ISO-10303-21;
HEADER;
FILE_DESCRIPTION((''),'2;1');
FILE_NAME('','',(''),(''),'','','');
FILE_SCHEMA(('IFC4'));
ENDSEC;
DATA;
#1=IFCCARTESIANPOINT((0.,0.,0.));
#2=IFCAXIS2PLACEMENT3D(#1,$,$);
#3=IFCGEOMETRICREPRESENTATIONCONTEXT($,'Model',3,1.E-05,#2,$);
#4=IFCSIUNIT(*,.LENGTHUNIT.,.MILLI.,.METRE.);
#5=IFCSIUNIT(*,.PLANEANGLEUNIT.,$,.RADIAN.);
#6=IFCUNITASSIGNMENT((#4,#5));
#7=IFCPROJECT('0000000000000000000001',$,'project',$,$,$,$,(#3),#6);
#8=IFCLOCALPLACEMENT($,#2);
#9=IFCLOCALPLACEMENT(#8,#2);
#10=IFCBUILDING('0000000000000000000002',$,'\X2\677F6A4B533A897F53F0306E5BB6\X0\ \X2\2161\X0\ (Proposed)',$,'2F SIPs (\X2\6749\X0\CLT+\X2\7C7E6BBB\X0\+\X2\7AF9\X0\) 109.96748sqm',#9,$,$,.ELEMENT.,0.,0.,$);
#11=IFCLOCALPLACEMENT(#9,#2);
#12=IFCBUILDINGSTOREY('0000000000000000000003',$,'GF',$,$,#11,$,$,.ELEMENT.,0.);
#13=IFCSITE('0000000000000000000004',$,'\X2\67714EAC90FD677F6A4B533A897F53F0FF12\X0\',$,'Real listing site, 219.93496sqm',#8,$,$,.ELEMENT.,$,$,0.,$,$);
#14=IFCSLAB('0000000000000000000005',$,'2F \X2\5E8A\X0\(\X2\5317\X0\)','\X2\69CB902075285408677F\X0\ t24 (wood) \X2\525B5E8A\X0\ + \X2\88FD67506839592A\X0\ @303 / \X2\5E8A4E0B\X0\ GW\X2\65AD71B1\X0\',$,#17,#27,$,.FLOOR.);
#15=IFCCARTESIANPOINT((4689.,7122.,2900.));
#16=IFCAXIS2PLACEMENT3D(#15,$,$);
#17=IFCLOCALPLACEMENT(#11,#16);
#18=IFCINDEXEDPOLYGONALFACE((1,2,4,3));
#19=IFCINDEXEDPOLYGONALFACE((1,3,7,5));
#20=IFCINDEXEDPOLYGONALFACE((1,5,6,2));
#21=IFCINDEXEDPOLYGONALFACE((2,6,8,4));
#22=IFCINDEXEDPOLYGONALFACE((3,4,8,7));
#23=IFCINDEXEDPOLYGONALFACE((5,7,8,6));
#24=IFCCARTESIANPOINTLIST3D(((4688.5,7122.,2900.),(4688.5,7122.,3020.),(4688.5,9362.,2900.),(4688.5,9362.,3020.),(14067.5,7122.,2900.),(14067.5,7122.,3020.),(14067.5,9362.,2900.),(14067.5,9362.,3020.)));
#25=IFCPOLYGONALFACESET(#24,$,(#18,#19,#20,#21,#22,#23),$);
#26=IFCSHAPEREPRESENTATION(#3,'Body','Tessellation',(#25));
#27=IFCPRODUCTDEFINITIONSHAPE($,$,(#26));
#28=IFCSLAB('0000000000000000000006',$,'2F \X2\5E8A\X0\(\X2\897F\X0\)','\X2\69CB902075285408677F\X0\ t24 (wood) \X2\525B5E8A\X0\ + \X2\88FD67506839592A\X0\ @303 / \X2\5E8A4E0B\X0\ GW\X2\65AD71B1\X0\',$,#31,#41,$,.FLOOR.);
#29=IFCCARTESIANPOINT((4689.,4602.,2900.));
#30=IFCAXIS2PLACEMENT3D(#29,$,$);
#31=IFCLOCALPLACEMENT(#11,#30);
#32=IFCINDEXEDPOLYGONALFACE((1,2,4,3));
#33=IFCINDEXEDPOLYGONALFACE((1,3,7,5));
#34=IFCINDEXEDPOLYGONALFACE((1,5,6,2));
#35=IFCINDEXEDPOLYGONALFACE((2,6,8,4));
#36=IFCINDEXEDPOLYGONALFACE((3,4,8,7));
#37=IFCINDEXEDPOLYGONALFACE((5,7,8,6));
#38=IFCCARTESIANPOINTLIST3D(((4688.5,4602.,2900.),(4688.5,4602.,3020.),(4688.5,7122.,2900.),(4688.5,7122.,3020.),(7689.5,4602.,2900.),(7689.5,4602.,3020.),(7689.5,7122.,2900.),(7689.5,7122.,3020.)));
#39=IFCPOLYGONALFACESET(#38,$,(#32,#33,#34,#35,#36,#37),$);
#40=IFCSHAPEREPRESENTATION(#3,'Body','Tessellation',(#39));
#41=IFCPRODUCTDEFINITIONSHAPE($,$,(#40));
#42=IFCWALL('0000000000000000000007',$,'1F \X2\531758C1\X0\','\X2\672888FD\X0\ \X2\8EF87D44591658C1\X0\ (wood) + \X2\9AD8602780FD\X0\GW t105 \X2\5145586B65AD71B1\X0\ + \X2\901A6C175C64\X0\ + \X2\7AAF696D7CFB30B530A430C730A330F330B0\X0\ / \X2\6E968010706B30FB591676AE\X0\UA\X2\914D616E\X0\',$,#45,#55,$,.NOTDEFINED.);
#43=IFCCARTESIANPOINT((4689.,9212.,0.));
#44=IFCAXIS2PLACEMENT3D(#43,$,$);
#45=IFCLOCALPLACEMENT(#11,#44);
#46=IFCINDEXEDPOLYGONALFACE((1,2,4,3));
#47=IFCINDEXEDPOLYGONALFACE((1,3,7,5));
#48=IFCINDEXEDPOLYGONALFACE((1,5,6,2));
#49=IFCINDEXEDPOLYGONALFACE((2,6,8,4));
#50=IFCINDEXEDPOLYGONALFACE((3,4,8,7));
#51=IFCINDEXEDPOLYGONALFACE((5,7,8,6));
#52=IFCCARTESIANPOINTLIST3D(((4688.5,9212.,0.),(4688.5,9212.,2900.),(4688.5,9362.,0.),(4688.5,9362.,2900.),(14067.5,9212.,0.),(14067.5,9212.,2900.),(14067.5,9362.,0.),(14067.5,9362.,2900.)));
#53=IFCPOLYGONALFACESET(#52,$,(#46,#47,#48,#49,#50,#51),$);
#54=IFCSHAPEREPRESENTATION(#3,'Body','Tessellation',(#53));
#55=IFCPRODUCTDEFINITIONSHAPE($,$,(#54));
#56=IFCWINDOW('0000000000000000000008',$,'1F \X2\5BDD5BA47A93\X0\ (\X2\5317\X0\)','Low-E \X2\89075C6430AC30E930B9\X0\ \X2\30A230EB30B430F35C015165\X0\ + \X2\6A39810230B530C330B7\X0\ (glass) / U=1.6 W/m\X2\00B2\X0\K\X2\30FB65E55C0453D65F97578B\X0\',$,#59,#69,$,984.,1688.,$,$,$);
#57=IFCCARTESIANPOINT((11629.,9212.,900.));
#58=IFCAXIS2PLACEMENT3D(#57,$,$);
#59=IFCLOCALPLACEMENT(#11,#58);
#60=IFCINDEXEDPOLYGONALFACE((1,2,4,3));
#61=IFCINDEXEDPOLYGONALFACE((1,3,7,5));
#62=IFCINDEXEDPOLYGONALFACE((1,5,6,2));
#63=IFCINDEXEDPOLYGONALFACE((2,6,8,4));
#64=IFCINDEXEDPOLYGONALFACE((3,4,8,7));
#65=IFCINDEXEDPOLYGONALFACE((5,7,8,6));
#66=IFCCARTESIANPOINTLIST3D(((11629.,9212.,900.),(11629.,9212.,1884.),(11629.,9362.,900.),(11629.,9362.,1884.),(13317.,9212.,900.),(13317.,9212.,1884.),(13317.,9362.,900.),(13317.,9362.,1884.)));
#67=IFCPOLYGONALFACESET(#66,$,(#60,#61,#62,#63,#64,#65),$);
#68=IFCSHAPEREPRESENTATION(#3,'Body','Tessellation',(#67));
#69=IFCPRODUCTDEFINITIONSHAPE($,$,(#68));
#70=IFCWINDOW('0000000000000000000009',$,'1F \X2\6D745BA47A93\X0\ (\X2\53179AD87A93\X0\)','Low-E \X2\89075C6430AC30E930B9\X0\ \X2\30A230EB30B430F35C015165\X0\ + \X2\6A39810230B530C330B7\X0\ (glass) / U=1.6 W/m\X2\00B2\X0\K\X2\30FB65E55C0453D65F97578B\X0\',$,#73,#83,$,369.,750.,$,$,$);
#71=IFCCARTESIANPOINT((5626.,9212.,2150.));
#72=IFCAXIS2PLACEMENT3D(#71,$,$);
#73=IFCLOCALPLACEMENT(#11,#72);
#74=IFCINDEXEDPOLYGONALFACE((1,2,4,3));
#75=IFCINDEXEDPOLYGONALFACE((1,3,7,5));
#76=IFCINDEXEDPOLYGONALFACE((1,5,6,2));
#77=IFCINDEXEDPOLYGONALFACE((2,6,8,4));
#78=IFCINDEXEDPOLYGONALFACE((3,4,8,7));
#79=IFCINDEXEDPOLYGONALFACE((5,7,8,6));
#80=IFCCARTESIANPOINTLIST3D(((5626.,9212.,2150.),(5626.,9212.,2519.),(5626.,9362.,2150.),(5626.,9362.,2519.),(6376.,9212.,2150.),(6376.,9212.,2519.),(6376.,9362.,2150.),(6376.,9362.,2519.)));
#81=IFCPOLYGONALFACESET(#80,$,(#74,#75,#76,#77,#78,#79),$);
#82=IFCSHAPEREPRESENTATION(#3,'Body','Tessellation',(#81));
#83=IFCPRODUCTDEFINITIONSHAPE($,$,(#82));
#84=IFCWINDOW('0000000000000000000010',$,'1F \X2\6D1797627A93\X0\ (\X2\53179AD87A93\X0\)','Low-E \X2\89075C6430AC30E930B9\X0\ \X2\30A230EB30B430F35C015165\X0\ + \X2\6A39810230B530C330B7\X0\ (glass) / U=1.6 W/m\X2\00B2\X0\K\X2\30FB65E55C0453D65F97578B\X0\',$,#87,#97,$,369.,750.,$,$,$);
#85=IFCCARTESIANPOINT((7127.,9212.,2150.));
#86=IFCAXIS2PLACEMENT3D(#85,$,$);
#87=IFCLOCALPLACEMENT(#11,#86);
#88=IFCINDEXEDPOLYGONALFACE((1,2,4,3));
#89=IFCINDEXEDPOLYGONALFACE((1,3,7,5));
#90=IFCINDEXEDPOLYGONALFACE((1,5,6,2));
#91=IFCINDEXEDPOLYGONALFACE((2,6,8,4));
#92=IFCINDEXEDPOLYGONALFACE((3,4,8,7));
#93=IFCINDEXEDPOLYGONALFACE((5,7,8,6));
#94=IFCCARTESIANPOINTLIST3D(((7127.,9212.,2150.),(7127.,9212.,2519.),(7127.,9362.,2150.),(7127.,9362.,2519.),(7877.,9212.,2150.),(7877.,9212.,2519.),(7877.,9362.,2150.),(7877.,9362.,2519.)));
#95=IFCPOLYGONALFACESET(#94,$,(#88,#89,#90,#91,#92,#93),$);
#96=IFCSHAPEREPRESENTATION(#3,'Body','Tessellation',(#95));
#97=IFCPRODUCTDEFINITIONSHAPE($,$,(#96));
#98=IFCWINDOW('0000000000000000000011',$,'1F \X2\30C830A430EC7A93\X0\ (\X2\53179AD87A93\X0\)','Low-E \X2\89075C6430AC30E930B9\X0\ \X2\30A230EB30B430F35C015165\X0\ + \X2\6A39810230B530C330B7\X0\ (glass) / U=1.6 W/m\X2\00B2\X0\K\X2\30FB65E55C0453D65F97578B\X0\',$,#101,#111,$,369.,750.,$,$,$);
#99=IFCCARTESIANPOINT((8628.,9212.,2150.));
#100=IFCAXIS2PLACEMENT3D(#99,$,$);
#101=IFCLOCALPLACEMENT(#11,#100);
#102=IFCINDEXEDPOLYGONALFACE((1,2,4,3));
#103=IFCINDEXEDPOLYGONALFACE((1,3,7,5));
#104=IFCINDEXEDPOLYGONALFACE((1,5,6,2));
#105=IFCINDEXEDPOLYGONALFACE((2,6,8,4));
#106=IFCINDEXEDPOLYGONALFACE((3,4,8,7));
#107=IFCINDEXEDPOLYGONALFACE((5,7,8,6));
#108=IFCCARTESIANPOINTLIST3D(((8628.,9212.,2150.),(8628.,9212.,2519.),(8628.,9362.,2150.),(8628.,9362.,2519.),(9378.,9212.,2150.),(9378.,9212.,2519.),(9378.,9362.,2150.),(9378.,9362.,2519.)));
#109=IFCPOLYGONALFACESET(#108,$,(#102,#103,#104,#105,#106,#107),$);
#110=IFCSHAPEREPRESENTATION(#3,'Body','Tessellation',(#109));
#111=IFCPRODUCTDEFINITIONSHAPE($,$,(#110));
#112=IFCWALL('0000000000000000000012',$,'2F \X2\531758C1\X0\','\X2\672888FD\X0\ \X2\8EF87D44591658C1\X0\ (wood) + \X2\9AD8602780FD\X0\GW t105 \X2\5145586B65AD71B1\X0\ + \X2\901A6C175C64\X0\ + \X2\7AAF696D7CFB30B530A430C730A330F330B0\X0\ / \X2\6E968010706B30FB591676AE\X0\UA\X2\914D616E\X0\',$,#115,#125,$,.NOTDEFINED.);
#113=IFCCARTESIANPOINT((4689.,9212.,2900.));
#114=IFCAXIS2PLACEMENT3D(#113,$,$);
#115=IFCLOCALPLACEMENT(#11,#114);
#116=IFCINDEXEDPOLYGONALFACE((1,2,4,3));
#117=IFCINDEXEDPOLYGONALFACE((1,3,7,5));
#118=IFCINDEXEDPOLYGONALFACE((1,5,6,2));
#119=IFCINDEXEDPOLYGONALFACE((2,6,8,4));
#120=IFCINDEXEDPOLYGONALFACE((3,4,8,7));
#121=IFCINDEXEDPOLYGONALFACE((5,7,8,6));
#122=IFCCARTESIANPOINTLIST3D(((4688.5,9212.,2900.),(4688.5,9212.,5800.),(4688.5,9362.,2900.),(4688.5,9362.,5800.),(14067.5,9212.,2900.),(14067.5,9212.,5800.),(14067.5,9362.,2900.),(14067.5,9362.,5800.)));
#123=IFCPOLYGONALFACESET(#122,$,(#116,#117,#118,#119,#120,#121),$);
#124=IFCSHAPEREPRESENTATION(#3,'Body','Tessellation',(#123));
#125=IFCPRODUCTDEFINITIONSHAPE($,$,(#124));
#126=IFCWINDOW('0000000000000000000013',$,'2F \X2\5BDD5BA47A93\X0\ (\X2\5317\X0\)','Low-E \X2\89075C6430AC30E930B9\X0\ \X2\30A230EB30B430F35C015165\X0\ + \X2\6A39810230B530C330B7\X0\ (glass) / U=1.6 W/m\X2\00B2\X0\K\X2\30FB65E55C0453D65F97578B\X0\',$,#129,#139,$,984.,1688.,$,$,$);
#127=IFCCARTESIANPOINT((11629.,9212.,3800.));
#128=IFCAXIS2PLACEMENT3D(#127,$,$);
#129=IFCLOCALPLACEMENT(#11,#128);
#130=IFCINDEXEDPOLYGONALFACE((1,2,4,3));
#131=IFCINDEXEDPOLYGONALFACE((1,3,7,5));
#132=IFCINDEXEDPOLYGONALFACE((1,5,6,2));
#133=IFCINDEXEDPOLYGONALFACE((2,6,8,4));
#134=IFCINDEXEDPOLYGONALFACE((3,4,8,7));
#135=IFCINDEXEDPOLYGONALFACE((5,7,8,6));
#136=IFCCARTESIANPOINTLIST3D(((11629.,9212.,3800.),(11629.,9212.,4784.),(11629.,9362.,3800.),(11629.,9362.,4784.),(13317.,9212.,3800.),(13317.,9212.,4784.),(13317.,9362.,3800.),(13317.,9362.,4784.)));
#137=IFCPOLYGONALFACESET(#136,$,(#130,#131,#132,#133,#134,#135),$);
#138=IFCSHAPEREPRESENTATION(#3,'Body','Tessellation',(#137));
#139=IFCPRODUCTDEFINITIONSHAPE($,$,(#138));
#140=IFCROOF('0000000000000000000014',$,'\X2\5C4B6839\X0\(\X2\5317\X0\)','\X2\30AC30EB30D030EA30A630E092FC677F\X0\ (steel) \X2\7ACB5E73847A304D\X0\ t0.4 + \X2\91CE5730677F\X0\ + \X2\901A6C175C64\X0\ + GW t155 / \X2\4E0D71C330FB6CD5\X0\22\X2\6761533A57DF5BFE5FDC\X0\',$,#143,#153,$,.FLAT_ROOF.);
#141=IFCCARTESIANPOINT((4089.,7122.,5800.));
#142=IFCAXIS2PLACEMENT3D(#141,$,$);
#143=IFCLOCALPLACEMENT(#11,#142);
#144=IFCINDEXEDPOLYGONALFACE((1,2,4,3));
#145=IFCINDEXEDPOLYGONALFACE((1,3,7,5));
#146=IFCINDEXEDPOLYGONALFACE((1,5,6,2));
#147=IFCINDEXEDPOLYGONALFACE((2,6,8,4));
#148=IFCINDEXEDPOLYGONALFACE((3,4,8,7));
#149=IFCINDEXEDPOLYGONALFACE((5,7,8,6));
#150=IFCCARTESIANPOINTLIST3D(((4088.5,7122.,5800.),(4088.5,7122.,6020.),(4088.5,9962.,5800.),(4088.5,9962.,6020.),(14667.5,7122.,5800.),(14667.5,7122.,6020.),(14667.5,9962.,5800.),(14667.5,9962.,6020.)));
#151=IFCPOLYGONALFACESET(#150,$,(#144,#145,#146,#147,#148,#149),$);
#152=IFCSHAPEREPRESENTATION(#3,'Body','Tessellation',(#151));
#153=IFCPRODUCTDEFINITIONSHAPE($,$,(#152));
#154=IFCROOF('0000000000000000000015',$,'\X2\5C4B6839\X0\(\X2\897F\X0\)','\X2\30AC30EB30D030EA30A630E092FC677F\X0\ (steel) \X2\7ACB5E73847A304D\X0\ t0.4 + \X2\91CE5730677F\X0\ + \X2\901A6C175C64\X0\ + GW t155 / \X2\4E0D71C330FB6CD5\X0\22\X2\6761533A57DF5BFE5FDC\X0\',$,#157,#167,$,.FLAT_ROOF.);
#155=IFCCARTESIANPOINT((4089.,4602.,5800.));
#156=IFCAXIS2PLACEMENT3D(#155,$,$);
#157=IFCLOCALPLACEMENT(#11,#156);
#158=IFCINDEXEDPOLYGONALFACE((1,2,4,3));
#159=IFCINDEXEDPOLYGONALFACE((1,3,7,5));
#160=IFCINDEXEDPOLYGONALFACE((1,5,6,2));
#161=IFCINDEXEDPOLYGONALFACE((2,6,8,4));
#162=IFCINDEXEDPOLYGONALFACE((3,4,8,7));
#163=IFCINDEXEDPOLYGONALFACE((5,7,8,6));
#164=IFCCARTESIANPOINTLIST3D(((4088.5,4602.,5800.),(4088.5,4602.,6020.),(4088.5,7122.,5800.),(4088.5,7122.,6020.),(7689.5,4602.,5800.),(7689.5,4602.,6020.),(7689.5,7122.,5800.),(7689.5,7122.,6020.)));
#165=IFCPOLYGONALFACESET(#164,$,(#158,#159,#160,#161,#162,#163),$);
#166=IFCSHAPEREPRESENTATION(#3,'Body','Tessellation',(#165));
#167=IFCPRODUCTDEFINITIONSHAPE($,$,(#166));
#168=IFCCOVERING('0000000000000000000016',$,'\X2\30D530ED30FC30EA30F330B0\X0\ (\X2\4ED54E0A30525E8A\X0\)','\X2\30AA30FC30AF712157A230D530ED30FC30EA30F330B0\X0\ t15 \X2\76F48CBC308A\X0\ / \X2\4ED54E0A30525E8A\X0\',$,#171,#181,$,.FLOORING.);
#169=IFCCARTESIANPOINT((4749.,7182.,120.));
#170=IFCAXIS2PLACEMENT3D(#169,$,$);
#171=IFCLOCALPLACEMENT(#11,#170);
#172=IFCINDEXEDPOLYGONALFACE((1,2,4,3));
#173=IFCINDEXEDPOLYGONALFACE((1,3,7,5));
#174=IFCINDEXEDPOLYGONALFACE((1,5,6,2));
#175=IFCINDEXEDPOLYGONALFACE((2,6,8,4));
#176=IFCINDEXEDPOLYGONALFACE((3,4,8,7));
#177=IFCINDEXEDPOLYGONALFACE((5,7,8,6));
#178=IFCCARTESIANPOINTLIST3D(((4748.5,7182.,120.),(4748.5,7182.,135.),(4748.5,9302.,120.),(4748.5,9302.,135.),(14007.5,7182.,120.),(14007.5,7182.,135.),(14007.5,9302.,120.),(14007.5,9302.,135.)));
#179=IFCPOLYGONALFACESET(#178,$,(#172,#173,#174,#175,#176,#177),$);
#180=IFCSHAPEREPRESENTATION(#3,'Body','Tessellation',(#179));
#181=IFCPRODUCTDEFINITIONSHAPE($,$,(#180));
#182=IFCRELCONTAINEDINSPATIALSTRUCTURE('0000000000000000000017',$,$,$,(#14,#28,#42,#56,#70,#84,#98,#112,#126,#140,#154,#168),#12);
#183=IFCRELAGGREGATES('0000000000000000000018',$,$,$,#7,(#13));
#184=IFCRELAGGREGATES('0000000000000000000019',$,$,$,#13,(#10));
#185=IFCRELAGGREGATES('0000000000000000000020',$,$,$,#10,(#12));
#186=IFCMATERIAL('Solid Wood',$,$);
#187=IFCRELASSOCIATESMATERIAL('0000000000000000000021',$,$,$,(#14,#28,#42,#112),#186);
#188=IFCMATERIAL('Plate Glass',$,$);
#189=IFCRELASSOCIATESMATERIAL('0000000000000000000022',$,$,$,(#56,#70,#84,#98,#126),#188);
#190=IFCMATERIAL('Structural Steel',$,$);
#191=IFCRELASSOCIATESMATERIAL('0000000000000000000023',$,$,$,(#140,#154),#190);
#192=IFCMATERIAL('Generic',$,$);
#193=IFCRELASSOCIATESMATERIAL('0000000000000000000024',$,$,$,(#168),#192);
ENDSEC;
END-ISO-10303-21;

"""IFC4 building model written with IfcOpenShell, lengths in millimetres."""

from ifc_helpers import new_model, si_unit, frame, frame_2d, origin, place, context, project, spatial, rectangle, extrude, material, element, fill, save


model = new_model("IFC4")

# Units and contexts
model_context = context("Model", 3, precision=1e-05, world=origin())
ifc_project = project(units=[si_unit("LENGTHUNIT", "METRE", prefix="MILLI"), si_unit("PLANEANGLEUNIT", "RADIAN")], contexts=[model_context])

# Site, building, storey
site_placement = place(None, origin())
site = spatial("IfcSite", under=ifc_project, at=site_placement, Name="東京都板橋区西台２", ObjectType="Real listing site, 219.93496sqm", CompositionType="ELEMENT", RefElevation=0.0)
building_placement = place(site_placement, origin())
building = spatial("IfcBuilding", under=site, at=building_placement, Name="板橋区西台の家 Ⅱ (Proposed)", ObjectType="2F SIPs (杉CLT+籾殻+竹) 109.96748sqm", CompositionType="ELEMENT", ElevationOfRefHeight=0.0, ElevationOfTerrain=0.0)
storey_placement = place(building_placement, origin())
storey = spatial("IfcBuildingStorey", under=building, at=storey_placement, Name="GF", CompositionType="ELEMENT", Elevation=0.0)

# Slabs
ifc_material_1 = material(Name="Solid Wood")
slab_1_placement = place(storey_placement, frame((4689.0, 7122.0, 2900.0)))
element("IfcSlab", 1, at=slab_1_placement, inside=storey, material=ifc_material_1, Name="2F 床(北)", Description="構造用合板 t24 (wood) 剛床 + 製材根太 @303 / 床下 GW断熱", PredefinedType="FLOOR", context=model_context, shape_type="SweptSolid", body=[
    extrude(rectangle(XDim=9379.0, YDim=2240.0, at=frame_2d((4689.0, 1120.0))), frame((4689.0, 7122.0, 2900.0)), (0.0, 0.0, 1.0), 120.0),
])
slab_2_placement = place(storey_placement, frame((4689.0, 4602.0, 2900.0)))
element("IfcSlab", 2, at=slab_2_placement, inside=storey, material=ifc_material_1, Name="2F 床(西)", Description="構造用合板 t24 (wood) 剛床 + 製材根太 @303 / 床下 GW断熱", PredefinedType="FLOOR", context=model_context, shape_type="SweptSolid", body=[
    extrude(rectangle(XDim=3001.0, YDim=2520.0, at=frame_2d((1500.0, 1260.0))), frame((4689.0, 4602.0, 2900.0)), (0.0, 0.0, 1.0), 120.0),
])

# Wall, openings, windows
wall_1_placement = place(storey_placement, frame((4689.0, 9212.0, 0.0)))
wall_1 = element("IfcWall", 3, at=wall_1_placement, inside=storey, material=ifc_material_1, Name="1F 北壁", Description="木製 軸組外壁 (wood) + 高性能GW t105 充填断熱 + 通気層 + 窯業系サイディング / 準耐火・外皮UA配慮", PredefinedType="NOTDEFINED", context=model_context, shape_type="SweptSolid", body=[
    extrude(rectangle(XDim=9379.0, YDim=150.0, at=frame_2d((4689.0, 75.0))), frame((4689.0, 9212.0, 0.0)), (0.0, 0.0, 1.0), 2900.0),
])
opening_1_placement = place(storey_placement, frame((11629.0, 9212.0, 900.0)))
opening_1 = element("IfcOpeningElement", 4, at=opening_1_placement, cuts=wall_1, PredefinedType="NOTDEFINED", context=model_context, shape_type="SweptSolid", body=[
    extrude(rectangle(XDim=1688.0, YDim=150.0, at=frame_2d((844.0, 75.0))), frame((11629.0, 9212.0, 900.0)), (0.0, 0.0, 1.0), 984.0),
])
opening_2_placement = place(storey_placement, frame((5626.0, 9212.0, 2150.0)))
opening_2 = element("IfcOpeningElement", 5, at=opening_2_placement, cuts=wall_1, PredefinedType="NOTDEFINED", context=model_context, shape_type="SweptSolid", body=[
    extrude(rectangle(XDim=750.0, YDim=150.0, at=frame_2d((375.0, 75.0))), frame((5626.0, 9212.0, 2150.0)), (0.0, 0.0, 1.0), 369.0),
])
opening_3_placement = place(storey_placement, frame((7127.0, 9212.0, 2150.0)))
opening_3 = element("IfcOpeningElement", 6, at=opening_3_placement, cuts=wall_1, PredefinedType="NOTDEFINED", context=model_context, shape_type="SweptSolid", body=[
    extrude(rectangle(XDim=750.0, YDim=150.0, at=frame_2d((375.0, 75.0))), frame((7127.0, 9212.0, 2150.0)), (0.0, 0.0, 1.0), 369.0),
])
opening_4_placement = place(storey_placement, frame((8628.0, 9212.0, 2150.0)))
opening_4 = element("IfcOpeningElement", 7, at=opening_4_placement, cuts=wall_1, PredefinedType="NOTDEFINED", context=model_context, shape_type="SweptSolid", body=[
    extrude(rectangle(XDim=750.0, YDim=150.0, at=frame_2d((375.0, 75.0))), frame((8628.0, 9212.0, 2150.0)), (0.0, 0.0, 1.0), 369.0),
])
ifc_material_2 = material(Name="Plate Glass")
window_1_placement = place(storey_placement, frame((11629.0, 9212.0, 900.0)))
window_1 = element("IfcWindow", 8, at=window_1_placement, inside=storey, material=ifc_material_2, Name="1F 寝室窓 (北)", Description="Low-E 複層ガラス アルゴン封入 + 樹脂サッシ (glass) / U=1.6 W/m²K・日射取得型", OverallHeight=984.0, OverallWidth=1688.0, context=model_context, shape_type="SweptSolid", body=[
    extrude(rectangle(XDim=1688.0, YDim=150.0, at=frame_2d((844.0, 75.0))), frame((11629.0, 9212.0, 900.0)), (0.0, 0.0, 1.0), 984.0),
])
fill(opening_1, window_1)
window_2_placement = place(storey_placement, frame((5626.0, 9212.0, 2150.0)))
window_2 = element("IfcWindow", 9, at=window_2_placement, inside=storey, material=ifc_material_2, Name="1F 浴室窓 (北高窓)", Description="Low-E 複層ガラス アルゴン封入 + 樹脂サッシ (glass) / U=1.6 W/m²K・日射取得型", OverallHeight=369.0, OverallWidth=750.0, context=model_context, shape_type="SweptSolid", body=[
    extrude(rectangle(XDim=750.0, YDim=150.0, at=frame_2d((375.0, 75.0))), frame((5626.0, 9212.0, 2150.0)), (0.0, 0.0, 1.0), 369.0),
])
fill(opening_2, window_2)
window_3_placement = place(storey_placement, frame((7127.0, 9212.0, 2150.0)))
window_3 = element("IfcWindow", 10, at=window_3_placement, inside=storey, material=ifc_material_2, Name="1F 洗面窓 (北高窓)", Description="Low-E 複層ガラス アルゴン封入 + 樹脂サッシ (glass) / U=1.6 W/m²K・日射取得型", OverallHeight=369.0, OverallWidth=750.0, context=model_context, shape_type="SweptSolid", body=[
    extrude(rectangle(XDim=750.0, YDim=150.0, at=frame_2d((375.0, 75.0))), frame((7127.0, 9212.0, 2150.0)), (0.0, 0.0, 1.0), 369.0),
])
fill(opening_3, window_3)
window_4_placement = place(storey_placement, frame((8628.0, 9212.0, 2150.0)))
window_4 = element("IfcWindow", 11, at=window_4_placement, inside=storey, material=ifc_material_2, Name="1F トイレ窓 (北高窓)", Description="Low-E 複層ガラス アルゴン封入 + 樹脂サッシ (glass) / U=1.6 W/m²K・日射取得型", OverallHeight=369.0, OverallWidth=750.0, context=model_context, shape_type="SweptSolid", body=[
    extrude(rectangle(XDim=750.0, YDim=150.0, at=frame_2d((375.0, 75.0))), frame((8628.0, 9212.0, 2150.0)), (0.0, 0.0, 1.0), 369.0),
])
fill(opening_4, window_4)

# Wall, opening, window
wall_2_placement = place(storey_placement, frame((4689.0, 9212.0, 2900.0)))
wall_2 = element("IfcWall", 12, at=wall_2_placement, inside=storey, material=ifc_material_1, Name="2F 北壁", Description="木製 軸組外壁 (wood) + 高性能GW t105 充填断熱 + 通気層 + 窯業系サイディング / 準耐火・外皮UA配慮", PredefinedType="NOTDEFINED", context=model_context, shape_type="SweptSolid", body=[
    extrude(rectangle(XDim=9379.0, YDim=150.0, at=frame_2d((4689.0, 75.0))), frame((4689.0, 9212.0, 2900.0)), (0.0, 0.0, 1.0), 2900.0),
])
opening_5_placement = place(storey_placement, frame((11629.0, 9212.0, 3800.0)))
opening_5 = element("IfcOpeningElement", 13, at=opening_5_placement, cuts=wall_2, PredefinedType="NOTDEFINED", context=model_context, shape_type="SweptSolid", body=[
    extrude(rectangle(XDim=1688.0, YDim=150.0, at=frame_2d((844.0, 75.0))), frame((11629.0, 9212.0, 3800.0)), (0.0, 0.0, 1.0), 984.0),
])
window_5_placement = place(storey_placement, frame((11629.0, 9212.0, 3800.0)))
window_5 = element("IfcWindow", 14, at=window_5_placement, inside=storey, material=ifc_material_2, Name="2F 寝室窓 (北)", Description="Low-E 複層ガラス アルゴン封入 + 樹脂サッシ (glass) / U=1.6 W/m²K・日射取得型", OverallHeight=984.0, OverallWidth=1688.0, context=model_context, shape_type="SweptSolid", body=[
    extrude(rectangle(XDim=1688.0, YDim=150.0, at=frame_2d((844.0, 75.0))), frame((11629.0, 9212.0, 3800.0)), (0.0, 0.0, 1.0), 984.0),
])
fill(opening_5, window_5)

# Roofs
ifc_material_3 = material(Name="Structural Steel")
for number, where, name in (
    (15, (4089.0, 7122.0, 5800.0), "屋根(北)"),
):
    element("IfcRoof", number, at=place(storey_placement, frame(where)), inside=storey, material=ifc_material_3, Name=name, Description="ガルバリウム鋼板 (steel) 立平葺き t0.4 + 野地板 + 通気層 + GW t155 / 不燃・法22条区域対応", PredefinedType="FLAT_ROOF", context=model_context, shape_type="SweptSolid", body=[
        extrude(rectangle(XDim=10579.0, YDim=2840.0, at=frame_2d((5289.0, 1420.0))), frame((4089.0, 7122.0, 5800.0)), (0.0, 0.0, 1.0), 220.0),
    ])
roof_placement = place(storey_placement, frame((4089.0, 4602.0, 5800.0)))
element("IfcRoof", 16, at=roof_placement, inside=storey, material=ifc_material_3, Name="屋根(西)", Description="ガルバリウム鋼板 (steel) 立平葺き t0.4 + 野地板 + 通気層 + GW t155 / 不燃・法22条区域対応", PredefinedType="FLAT_ROOF", context=model_context, shape_type="SweptSolid", body=[
    extrude(rectangle(XDim=3601.0, YDim=2520.0, at=frame_2d((1800.0, 1260.0))), frame((4089.0, 4602.0, 5800.0)), (0.0, 0.0, 1.0), 220.0),
])

# Covering
ifc_material_4 = material(Name="Generic")
covering_1_placement = place(storey_placement, frame((4749.0, 7182.0, 120.0)))
element("IfcCovering", 17, at=covering_1_placement, inside=storey, material=ifc_material_4, Name="フローリング (仕上げ床)", Description="オーク無垢フローリング t15 直貼り / 仕上げ床", PredefinedType="FLOORING", context=model_context, shape_type="SweptSolid", body=[
    extrude(rectangle(XDim=9259.0, YDim=2120.0, at=frame_2d((4629.0, 1060.0))), frame((4749.0, 7182.0, 120.0)), (0.0, 0.0, 1.0), 15.0),
])

save(model, "model.ifc")
